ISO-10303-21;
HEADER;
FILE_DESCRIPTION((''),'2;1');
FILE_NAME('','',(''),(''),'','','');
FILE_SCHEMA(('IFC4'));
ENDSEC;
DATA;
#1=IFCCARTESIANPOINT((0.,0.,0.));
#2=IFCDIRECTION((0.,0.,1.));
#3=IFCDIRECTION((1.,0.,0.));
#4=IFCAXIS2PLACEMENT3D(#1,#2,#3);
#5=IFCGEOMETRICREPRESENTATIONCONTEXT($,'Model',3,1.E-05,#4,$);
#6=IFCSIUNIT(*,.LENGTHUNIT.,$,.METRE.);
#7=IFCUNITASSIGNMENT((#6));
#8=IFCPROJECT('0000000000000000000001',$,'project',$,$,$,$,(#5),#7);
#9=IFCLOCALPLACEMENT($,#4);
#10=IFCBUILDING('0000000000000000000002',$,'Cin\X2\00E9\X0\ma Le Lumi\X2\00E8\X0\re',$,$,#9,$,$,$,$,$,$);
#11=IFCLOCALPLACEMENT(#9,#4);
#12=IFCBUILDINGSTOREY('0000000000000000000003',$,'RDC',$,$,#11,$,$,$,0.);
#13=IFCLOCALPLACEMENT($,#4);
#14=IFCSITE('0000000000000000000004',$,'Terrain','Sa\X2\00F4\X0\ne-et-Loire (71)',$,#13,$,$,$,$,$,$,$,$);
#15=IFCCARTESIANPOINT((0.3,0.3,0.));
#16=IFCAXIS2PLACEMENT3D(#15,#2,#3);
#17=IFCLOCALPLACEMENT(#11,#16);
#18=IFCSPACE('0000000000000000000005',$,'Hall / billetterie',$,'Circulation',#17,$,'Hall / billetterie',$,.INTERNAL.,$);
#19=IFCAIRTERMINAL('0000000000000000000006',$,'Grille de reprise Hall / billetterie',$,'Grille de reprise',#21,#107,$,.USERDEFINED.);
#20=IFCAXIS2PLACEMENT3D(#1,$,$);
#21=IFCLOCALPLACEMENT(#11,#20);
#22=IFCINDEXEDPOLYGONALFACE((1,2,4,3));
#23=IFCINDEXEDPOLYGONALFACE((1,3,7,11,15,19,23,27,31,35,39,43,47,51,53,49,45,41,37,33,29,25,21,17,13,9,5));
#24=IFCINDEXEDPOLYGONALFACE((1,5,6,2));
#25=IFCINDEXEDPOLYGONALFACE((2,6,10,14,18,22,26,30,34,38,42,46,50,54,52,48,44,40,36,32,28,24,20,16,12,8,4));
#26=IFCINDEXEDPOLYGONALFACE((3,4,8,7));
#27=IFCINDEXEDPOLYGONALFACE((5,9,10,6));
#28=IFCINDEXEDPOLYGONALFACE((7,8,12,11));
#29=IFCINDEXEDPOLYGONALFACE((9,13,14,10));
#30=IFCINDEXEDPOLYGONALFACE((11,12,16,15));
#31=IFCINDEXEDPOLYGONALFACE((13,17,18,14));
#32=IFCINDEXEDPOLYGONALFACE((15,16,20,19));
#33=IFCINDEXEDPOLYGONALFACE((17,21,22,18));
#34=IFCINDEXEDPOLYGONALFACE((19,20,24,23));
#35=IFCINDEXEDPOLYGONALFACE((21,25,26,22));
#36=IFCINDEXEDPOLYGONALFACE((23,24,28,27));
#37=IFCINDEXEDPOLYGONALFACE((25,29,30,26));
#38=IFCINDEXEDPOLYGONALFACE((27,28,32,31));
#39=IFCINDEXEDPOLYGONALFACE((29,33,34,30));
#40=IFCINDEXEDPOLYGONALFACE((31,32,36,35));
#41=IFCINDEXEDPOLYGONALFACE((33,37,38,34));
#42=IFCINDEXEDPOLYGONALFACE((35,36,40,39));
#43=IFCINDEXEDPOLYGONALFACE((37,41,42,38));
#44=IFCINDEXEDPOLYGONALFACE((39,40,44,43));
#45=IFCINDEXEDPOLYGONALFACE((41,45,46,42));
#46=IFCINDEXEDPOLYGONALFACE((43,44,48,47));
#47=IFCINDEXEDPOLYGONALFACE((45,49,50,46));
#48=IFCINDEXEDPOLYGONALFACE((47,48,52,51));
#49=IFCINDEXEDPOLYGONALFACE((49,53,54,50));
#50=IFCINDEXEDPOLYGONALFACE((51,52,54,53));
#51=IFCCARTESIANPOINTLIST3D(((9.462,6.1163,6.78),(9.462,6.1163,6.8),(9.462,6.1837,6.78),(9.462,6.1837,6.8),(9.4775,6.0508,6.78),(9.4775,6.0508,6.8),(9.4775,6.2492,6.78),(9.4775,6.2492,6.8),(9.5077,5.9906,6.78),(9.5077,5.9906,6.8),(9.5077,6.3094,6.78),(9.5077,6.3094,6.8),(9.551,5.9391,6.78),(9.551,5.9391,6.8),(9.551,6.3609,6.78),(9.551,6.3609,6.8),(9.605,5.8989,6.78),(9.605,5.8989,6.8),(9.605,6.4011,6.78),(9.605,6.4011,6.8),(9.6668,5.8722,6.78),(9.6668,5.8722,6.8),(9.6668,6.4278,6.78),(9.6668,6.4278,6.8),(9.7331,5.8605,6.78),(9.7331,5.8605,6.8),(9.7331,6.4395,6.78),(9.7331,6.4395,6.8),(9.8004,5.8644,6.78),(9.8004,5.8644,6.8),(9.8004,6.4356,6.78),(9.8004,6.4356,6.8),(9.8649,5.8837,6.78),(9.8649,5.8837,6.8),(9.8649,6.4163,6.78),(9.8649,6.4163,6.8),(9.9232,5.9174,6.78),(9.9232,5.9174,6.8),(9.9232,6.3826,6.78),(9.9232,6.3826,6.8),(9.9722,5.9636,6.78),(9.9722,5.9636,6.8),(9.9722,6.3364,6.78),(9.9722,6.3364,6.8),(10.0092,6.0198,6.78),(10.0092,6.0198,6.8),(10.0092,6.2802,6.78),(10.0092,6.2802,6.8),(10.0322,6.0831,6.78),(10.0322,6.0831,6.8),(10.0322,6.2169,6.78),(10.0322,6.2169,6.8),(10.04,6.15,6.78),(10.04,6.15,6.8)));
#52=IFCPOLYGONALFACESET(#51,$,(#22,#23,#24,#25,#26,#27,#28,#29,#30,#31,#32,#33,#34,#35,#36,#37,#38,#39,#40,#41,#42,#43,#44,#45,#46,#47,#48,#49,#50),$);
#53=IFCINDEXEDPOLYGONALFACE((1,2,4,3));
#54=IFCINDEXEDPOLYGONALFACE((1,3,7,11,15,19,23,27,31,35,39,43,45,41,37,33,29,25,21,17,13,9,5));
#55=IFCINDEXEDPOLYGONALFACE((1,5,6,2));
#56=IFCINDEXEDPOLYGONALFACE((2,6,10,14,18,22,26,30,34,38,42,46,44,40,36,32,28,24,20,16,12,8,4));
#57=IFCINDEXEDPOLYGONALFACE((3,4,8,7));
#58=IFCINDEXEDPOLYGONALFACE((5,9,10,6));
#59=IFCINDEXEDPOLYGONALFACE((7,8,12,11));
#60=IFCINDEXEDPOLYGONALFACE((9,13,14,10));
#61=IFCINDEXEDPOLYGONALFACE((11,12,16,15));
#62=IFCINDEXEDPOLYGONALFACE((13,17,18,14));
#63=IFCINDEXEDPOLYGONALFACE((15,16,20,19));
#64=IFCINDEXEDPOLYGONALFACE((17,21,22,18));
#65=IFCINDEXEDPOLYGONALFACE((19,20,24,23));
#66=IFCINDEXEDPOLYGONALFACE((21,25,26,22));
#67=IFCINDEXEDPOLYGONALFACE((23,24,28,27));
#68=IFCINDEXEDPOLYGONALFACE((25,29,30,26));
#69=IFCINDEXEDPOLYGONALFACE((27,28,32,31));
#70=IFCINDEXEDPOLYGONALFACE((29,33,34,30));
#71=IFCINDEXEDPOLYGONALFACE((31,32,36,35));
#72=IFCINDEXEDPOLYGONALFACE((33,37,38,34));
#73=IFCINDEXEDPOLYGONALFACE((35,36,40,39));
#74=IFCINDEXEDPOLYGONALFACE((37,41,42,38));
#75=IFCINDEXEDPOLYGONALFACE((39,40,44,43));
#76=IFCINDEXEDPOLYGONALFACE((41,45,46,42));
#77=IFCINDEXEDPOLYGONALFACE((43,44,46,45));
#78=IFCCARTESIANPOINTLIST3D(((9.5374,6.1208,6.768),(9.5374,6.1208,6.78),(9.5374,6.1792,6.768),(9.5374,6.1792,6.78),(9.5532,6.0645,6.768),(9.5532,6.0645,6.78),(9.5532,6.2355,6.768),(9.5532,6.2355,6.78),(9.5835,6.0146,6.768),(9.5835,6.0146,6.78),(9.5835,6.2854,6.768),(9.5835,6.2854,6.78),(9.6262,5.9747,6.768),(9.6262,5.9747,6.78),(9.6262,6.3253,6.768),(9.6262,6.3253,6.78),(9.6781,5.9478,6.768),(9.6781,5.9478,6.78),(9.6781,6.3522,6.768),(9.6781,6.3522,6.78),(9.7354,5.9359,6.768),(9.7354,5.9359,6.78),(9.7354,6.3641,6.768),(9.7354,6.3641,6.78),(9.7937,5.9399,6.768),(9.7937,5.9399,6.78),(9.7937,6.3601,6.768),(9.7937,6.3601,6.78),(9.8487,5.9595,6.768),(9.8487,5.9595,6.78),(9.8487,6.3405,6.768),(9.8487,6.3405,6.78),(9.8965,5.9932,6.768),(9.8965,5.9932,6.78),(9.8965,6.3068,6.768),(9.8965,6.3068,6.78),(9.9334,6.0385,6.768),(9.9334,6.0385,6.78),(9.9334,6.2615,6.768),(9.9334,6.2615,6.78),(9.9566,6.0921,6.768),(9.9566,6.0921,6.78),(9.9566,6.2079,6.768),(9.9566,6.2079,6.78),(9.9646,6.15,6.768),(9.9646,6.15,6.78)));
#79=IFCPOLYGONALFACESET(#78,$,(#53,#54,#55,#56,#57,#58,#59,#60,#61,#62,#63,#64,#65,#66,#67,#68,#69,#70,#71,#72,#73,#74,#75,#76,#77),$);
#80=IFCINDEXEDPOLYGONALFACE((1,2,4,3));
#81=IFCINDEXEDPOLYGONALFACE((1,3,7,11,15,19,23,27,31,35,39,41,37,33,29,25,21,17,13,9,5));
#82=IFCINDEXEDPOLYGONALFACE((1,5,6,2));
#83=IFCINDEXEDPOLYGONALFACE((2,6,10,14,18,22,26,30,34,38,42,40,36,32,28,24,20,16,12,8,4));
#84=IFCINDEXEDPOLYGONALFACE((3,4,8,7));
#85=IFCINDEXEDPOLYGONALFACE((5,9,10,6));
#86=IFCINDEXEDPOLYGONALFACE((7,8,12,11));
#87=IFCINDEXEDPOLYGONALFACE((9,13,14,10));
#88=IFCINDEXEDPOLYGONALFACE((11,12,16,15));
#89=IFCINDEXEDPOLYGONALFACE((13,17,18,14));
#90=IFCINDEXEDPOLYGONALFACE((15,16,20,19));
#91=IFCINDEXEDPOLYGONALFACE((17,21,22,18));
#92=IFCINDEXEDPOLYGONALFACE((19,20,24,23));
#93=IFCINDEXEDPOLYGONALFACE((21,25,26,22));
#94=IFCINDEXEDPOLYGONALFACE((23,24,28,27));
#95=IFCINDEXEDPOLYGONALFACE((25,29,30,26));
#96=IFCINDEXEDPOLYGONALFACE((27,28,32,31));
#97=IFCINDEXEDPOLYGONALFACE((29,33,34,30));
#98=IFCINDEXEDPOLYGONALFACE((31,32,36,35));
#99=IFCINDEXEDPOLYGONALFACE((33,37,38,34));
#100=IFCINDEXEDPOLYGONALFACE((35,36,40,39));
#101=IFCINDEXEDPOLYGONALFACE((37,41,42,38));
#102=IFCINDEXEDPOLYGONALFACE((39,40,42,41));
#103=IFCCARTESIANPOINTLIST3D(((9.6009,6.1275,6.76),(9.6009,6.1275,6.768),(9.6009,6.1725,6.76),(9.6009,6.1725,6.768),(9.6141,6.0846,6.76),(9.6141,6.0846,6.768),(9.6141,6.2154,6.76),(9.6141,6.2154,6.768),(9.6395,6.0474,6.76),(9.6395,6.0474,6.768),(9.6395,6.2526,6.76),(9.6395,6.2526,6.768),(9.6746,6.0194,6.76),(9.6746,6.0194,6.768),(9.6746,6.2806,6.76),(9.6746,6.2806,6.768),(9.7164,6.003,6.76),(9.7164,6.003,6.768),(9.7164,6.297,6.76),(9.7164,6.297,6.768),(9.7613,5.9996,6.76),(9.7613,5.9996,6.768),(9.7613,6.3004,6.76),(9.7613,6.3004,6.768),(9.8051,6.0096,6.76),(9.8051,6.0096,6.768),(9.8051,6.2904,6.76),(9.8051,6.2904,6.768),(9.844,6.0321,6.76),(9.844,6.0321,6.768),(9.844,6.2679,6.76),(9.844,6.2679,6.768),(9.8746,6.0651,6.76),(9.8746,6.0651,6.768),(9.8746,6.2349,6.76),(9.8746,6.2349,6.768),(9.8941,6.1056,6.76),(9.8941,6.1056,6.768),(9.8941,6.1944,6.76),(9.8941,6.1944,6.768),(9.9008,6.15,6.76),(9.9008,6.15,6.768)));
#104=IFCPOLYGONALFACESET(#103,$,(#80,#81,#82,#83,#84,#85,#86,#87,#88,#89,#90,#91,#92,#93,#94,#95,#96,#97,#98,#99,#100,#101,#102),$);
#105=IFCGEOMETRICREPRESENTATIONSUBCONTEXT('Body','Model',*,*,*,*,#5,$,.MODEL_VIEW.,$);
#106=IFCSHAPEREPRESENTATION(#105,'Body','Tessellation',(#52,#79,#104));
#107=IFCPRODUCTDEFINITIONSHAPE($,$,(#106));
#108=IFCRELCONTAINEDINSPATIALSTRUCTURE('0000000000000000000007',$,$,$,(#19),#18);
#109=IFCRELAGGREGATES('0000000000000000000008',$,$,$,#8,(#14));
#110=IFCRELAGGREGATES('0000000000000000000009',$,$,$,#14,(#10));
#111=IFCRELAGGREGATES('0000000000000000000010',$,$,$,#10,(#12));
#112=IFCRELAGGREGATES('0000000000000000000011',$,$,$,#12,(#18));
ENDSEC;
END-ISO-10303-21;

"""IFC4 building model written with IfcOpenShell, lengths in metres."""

from ifc_helpers import new_model, si_unit, frame, origin_with_axes, place, context, subcontext, project, spatial, circle, extrude, element, save


model = new_model("IFC4")

# Units and contexts
model_context = context("Model", 3, precision=1e-05, world=origin_with_axes())
body_context = subcontext(model_context, "Body", "Model", "MODEL_VIEW")
ifc_project = project(units=[si_unit("LENGTHUNIT", "METRE")], contexts=[model_context])

# Site, building, storey
site_placement = place(None, origin_with_axes())
site = spatial("IfcSite", under=ifc_project, at=site_placement, Name="Terrain", Description="Saône-et-Loire (71)")
building_placement = place(None, origin_with_axes())
building = spatial("IfcBuilding", under=site, at=building_placement, Name="Cinéma Le Lumière")
storey_placement = place(building_placement, origin_with_axes())
storey = spatial("IfcBuildingStorey", under=building, at=storey_placement, Name="RDC", Elevation=0.0)

# Shared definitions
space_1_placement = place(storey_placement, frame((0.3, 0.3, 0.0), z_axis=(0.0, 0.0, 1.0), x_axis=(1.0, 0.0, 0.0)))
space_1 = spatial("IfcSpace", under=storey, at=space_1_placement, Name="Hall / billetterie", ObjectType="Circulation", LongName="Hall / billetterie", PredefinedType="INTERNAL")

# Air terminal
air_terminal_1_placement = place(space_1_placement, frame((9.45, 5.85, 6.76), z_axis=(0.0, 0.0, 1.0), x_axis=(1.0, 0.0, 0.0)))
element("IfcAirTerminal", 1, at=air_terminal_1_placement, inside=space_1, Name="Grille de reprise Hall / billetterie", ObjectType="Grille de reprise", PredefinedType="USERDEFINED", context=body_context, shape_type="SweptSolid", body=[
    extrude(circle(Radius=0.29), frame((0.0, 0.0, 0.02), z_axis=(0.0, 0.0, 1.0), x_axis=(1.0, 0.0, 0.0)), (0.0, 0.0, 1.0), 0.02),
    extrude(circle(Radius=0.2146), frame((0.0, 0.0, 0.008), z_axis=(0.0, 0.0, 1.0), x_axis=(1.0, 0.0, 0.0)), (0.0, 0.0, 1.0), 0.012),
    extrude(circle(Radius=0.1508), origin_with_axes(), (0.0, 0.0, 1.0), 0.008),
])

save(model, "model.ifc")
